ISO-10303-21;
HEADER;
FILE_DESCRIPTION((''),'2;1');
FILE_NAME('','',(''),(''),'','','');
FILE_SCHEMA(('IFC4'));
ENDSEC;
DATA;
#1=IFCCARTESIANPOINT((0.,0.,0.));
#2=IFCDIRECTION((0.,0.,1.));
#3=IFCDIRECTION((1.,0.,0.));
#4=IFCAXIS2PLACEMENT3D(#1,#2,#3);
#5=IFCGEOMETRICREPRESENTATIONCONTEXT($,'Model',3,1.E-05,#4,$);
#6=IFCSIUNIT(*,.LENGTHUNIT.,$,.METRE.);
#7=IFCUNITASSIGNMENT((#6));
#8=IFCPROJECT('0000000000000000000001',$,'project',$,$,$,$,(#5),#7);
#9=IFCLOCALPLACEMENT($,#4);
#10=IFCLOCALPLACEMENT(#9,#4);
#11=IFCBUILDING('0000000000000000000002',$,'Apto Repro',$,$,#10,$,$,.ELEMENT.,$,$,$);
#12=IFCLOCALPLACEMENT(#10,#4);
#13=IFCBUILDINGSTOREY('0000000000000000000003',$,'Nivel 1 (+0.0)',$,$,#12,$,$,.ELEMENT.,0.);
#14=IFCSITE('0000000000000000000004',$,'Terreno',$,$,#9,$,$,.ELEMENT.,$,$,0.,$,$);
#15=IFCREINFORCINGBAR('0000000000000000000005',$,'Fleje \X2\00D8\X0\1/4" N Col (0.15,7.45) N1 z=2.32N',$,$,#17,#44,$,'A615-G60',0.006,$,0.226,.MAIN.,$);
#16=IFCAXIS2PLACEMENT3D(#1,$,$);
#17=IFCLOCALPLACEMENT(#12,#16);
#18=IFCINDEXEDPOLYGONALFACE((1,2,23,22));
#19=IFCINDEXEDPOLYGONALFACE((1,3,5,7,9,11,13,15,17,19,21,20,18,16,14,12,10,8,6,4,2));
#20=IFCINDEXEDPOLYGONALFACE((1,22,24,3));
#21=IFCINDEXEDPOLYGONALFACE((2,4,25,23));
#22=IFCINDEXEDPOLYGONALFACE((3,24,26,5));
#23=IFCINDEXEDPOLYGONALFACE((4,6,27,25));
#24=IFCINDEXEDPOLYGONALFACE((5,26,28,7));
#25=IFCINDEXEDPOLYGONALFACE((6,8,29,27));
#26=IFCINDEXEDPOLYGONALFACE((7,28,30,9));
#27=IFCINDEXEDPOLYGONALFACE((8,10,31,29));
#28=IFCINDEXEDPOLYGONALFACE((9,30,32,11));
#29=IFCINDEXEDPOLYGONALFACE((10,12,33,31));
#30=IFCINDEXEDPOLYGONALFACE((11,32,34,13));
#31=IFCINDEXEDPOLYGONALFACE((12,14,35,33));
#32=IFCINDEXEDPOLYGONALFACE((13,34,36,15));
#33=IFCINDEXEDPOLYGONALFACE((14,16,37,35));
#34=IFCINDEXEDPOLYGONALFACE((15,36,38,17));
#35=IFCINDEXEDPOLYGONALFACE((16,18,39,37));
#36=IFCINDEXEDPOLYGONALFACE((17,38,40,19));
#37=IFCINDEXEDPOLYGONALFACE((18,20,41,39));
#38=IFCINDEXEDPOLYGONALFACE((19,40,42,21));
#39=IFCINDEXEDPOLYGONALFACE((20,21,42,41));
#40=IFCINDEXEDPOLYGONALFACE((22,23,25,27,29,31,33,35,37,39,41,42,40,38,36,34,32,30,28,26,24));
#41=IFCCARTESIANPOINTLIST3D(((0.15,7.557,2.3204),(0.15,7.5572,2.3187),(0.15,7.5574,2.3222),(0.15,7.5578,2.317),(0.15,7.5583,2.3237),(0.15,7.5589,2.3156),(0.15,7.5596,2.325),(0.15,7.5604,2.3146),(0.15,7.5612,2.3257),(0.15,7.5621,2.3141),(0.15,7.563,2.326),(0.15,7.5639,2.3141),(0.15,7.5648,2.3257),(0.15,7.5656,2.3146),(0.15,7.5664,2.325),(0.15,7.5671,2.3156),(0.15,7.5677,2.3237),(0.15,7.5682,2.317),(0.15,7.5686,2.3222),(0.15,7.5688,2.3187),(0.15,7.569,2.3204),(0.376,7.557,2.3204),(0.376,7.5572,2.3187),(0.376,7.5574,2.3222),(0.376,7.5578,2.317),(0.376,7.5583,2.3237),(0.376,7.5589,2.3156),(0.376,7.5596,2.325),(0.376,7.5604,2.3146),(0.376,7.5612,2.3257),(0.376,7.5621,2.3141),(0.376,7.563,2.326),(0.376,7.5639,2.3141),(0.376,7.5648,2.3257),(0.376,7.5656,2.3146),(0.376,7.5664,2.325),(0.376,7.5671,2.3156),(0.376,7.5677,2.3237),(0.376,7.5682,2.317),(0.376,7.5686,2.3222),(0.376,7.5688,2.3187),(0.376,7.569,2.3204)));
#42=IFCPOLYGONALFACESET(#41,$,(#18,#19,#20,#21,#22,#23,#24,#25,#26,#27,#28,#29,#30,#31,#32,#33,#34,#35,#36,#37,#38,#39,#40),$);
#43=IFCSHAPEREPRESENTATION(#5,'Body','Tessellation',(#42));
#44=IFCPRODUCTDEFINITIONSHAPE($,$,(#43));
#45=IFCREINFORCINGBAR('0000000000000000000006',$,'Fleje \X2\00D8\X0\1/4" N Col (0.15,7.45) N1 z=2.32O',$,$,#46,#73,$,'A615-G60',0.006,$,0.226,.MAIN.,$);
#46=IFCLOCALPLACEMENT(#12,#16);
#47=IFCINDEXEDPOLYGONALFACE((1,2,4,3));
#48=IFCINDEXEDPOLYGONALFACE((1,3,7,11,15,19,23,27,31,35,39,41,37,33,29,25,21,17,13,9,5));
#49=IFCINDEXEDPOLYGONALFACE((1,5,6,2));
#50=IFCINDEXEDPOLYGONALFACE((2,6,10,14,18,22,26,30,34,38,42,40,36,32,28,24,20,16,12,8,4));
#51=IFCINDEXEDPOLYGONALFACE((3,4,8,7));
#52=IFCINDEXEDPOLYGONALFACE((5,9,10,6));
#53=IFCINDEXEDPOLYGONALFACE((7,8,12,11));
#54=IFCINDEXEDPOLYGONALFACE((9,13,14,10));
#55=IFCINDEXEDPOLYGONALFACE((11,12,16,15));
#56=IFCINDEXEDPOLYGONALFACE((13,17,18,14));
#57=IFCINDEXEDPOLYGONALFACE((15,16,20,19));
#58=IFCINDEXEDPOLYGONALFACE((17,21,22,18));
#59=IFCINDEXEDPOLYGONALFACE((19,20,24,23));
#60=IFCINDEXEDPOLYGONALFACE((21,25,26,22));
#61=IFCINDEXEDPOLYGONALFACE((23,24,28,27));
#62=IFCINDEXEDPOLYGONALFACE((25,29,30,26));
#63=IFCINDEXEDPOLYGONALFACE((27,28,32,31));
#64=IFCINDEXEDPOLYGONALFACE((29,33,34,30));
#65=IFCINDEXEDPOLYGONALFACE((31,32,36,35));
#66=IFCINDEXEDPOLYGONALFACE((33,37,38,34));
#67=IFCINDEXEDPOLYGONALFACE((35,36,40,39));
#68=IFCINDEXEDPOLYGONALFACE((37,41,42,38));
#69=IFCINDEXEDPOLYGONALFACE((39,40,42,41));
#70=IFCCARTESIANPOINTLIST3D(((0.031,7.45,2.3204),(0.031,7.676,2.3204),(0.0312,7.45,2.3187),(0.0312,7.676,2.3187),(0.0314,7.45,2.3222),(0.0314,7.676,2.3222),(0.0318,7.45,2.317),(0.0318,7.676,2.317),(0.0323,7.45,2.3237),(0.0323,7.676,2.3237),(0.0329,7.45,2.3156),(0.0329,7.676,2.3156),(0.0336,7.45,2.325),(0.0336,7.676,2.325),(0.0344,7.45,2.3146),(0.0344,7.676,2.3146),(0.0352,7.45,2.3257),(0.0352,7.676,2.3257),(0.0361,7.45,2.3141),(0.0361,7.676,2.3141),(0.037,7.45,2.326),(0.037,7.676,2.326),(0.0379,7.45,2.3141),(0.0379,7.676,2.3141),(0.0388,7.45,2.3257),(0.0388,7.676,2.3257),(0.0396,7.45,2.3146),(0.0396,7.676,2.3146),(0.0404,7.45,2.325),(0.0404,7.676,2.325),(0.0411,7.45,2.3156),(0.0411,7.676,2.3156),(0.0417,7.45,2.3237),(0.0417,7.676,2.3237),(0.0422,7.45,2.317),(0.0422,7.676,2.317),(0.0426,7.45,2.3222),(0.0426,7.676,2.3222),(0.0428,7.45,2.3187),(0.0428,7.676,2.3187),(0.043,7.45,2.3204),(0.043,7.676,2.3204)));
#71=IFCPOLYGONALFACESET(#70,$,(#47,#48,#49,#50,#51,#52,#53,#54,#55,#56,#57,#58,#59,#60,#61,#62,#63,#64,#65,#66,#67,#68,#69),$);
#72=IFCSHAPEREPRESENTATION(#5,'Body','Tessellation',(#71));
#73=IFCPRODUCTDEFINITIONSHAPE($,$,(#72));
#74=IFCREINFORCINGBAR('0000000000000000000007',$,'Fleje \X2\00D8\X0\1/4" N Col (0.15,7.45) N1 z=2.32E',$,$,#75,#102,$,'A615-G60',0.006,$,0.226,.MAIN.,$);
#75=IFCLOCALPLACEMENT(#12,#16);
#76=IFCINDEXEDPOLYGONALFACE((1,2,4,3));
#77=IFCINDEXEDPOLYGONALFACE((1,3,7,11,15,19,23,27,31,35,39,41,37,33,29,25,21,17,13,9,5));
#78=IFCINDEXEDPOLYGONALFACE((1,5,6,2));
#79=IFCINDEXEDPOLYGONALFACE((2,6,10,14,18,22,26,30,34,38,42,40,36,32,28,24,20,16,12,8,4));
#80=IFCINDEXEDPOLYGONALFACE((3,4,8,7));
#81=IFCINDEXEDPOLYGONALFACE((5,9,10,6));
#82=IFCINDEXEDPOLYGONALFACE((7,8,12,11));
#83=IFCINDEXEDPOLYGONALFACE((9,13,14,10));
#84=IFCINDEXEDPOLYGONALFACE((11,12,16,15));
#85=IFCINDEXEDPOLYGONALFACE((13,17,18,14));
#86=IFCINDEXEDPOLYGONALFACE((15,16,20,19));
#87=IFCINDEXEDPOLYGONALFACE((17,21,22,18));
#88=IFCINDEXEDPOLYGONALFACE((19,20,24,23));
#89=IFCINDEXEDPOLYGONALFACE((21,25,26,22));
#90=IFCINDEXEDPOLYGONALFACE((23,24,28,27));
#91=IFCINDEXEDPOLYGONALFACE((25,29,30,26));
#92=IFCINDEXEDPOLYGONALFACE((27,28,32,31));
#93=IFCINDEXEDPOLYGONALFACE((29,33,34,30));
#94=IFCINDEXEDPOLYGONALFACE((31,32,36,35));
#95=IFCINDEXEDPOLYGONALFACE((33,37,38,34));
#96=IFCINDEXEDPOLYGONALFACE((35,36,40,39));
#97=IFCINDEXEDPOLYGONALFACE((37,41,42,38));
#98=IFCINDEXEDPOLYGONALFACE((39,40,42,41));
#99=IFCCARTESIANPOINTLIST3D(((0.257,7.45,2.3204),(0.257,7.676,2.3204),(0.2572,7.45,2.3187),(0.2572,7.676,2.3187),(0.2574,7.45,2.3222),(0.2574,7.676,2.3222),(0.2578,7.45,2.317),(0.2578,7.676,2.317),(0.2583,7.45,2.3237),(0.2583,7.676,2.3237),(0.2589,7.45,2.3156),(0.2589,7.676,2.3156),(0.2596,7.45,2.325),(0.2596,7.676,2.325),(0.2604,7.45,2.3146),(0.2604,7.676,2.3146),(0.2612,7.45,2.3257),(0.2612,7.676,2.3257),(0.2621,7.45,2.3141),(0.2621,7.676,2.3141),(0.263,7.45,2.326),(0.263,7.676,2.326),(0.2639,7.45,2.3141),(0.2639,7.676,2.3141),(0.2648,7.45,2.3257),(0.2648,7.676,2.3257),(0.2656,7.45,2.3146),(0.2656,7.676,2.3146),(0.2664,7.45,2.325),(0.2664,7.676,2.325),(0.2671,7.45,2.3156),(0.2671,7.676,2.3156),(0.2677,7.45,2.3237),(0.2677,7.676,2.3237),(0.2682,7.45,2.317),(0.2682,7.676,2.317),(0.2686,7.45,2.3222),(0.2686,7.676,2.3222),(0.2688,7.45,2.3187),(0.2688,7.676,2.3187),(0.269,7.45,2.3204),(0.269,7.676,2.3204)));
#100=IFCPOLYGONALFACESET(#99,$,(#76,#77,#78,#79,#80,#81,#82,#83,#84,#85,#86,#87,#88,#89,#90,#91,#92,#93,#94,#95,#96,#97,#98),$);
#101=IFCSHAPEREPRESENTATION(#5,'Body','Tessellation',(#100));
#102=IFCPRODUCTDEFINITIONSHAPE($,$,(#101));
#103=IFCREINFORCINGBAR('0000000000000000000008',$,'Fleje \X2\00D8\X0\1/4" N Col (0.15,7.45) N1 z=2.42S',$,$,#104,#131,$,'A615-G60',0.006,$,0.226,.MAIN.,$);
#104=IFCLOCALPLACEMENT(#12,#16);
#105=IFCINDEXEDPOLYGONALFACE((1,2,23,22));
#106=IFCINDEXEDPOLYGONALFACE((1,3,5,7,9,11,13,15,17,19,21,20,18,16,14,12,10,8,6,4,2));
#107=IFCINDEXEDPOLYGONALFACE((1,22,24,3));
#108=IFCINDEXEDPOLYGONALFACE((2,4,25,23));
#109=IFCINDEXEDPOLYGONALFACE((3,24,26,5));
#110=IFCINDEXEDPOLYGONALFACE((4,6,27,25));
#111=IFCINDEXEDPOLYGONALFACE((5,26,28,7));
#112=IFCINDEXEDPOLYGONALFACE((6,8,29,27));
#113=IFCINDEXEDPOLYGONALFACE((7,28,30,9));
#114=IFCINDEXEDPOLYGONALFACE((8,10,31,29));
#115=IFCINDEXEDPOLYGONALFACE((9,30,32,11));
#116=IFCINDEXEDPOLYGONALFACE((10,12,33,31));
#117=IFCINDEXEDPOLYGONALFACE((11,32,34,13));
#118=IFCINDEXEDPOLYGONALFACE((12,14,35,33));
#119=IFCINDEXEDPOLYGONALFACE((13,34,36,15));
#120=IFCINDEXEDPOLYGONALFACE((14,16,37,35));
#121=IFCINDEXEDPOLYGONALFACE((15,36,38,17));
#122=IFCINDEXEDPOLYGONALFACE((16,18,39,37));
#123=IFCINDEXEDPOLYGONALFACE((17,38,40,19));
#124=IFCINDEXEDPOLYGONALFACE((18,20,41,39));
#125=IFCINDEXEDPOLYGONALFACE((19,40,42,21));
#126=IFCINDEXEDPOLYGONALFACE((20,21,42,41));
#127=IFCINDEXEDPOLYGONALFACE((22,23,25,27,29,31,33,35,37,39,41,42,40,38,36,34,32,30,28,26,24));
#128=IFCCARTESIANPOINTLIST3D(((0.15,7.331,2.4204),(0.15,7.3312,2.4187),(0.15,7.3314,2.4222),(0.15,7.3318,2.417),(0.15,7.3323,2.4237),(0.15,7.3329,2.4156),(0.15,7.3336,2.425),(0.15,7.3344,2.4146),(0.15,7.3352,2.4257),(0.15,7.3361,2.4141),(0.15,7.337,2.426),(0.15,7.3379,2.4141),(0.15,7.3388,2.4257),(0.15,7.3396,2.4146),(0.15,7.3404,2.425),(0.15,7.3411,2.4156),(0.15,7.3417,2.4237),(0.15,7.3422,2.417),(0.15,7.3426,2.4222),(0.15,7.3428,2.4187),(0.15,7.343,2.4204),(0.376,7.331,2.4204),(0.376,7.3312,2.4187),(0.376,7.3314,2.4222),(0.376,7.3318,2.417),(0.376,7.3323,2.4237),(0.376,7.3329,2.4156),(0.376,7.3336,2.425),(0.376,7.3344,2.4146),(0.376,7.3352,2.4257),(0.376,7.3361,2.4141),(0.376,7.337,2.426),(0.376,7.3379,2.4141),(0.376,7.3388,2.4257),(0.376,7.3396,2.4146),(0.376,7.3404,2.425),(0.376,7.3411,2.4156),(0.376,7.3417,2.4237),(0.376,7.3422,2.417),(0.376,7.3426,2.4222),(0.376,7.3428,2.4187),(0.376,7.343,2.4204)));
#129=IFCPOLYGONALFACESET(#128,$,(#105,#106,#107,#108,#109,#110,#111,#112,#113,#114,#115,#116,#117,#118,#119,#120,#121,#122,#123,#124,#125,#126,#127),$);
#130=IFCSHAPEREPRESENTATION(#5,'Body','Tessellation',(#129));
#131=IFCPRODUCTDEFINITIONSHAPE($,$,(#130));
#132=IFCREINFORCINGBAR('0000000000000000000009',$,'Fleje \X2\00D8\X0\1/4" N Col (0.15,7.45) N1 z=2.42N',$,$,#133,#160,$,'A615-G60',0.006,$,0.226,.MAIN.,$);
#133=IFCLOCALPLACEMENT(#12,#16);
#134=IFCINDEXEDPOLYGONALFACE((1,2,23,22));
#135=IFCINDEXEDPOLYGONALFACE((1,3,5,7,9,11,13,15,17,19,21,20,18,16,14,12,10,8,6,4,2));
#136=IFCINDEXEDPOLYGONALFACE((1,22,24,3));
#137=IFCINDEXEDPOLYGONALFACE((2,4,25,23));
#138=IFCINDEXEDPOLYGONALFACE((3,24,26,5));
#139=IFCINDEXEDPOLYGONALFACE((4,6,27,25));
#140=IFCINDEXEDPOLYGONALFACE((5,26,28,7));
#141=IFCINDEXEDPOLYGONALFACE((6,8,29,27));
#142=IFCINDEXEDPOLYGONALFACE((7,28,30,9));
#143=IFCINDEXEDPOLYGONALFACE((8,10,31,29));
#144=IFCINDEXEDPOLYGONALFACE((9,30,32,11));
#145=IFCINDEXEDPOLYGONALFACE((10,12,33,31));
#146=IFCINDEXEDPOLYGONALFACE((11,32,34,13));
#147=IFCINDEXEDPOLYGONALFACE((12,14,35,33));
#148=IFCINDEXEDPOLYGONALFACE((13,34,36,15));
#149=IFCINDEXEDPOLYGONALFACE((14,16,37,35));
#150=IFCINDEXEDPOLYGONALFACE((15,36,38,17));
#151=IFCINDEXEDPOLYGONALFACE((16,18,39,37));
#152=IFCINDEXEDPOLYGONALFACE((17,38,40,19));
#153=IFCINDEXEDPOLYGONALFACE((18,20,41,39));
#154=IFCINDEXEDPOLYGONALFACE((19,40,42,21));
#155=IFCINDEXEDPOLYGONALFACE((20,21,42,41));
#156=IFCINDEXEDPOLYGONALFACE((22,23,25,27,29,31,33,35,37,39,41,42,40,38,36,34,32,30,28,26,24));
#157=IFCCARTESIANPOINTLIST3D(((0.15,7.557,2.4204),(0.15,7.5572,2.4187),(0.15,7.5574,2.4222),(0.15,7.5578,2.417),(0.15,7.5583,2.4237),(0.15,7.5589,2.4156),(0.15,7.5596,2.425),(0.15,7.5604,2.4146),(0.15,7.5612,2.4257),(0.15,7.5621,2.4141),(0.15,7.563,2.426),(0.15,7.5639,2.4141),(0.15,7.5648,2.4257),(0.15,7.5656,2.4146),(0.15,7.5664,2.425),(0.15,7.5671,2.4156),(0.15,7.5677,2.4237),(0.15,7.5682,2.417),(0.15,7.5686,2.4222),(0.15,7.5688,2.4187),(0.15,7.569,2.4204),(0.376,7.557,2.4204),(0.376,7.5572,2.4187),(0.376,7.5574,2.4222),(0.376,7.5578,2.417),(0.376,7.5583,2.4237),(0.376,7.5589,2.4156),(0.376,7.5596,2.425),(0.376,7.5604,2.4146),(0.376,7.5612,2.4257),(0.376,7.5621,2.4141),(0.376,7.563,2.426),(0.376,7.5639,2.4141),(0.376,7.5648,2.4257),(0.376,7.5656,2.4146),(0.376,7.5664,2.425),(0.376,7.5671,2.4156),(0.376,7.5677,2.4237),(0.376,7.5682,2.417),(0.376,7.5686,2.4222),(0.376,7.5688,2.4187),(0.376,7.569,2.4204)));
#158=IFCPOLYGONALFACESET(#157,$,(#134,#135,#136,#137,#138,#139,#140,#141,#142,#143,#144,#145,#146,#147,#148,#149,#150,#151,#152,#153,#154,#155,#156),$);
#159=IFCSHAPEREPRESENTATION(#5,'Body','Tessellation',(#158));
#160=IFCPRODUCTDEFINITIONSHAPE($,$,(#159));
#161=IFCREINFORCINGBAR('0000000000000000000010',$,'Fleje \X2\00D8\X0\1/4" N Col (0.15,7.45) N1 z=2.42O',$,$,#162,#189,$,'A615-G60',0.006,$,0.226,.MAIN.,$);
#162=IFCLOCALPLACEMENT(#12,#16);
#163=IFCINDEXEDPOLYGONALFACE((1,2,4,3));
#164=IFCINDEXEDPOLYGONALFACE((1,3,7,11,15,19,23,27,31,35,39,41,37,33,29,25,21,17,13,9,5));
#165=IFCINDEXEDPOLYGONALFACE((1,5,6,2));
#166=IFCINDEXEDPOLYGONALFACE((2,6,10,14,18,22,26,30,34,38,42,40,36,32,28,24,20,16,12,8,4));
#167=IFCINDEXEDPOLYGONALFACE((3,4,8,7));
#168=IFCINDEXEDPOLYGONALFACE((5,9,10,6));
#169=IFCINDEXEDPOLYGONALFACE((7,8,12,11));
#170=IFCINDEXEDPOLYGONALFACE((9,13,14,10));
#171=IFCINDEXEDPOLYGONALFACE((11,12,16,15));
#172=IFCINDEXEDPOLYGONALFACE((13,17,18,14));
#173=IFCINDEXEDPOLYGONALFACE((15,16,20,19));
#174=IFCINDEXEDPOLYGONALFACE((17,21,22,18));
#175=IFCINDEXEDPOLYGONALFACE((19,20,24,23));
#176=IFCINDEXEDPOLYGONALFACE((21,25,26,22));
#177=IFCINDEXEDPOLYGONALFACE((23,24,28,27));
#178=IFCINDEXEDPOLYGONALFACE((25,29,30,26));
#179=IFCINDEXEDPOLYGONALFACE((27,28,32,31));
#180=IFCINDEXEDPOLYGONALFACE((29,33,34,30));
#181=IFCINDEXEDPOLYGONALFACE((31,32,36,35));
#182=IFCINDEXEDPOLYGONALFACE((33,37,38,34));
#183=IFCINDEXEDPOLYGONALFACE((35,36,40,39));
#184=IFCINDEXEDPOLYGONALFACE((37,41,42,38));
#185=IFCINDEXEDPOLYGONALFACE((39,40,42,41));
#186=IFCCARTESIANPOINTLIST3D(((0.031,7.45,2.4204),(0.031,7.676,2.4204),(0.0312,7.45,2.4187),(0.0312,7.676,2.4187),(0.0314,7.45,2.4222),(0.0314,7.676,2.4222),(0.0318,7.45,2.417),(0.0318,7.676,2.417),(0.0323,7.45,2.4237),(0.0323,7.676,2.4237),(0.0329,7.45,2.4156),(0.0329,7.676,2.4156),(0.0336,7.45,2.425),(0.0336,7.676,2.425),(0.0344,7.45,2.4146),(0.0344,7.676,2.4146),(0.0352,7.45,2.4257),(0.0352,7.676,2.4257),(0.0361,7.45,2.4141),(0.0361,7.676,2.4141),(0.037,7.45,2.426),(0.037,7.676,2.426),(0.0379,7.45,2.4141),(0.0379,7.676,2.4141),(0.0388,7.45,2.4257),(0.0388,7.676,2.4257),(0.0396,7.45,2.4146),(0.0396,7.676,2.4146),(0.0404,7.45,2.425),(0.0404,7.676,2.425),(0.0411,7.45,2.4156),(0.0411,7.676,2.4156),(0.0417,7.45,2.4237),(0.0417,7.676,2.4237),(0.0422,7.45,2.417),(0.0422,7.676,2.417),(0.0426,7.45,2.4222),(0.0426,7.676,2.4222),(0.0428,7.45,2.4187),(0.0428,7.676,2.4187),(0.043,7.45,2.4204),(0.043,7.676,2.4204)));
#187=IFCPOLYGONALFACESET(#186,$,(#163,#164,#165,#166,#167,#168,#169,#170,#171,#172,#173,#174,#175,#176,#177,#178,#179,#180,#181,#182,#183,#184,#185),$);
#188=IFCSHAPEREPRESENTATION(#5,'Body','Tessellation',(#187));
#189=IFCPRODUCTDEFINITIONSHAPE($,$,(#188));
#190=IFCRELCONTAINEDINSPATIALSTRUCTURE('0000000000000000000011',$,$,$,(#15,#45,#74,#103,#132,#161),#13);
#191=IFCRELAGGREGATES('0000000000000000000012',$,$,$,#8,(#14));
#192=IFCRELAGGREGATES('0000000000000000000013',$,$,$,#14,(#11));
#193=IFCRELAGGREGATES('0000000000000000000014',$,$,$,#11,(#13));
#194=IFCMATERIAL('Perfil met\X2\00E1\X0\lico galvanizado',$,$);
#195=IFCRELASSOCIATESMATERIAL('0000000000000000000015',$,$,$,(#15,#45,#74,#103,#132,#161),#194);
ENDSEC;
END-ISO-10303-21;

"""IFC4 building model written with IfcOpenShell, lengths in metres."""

from ifc_helpers import new_model, si_unit, frame, origin_with_axes, origin_2d_with_axis, place, context, project, spatial, circle, extrude, material, element, save


model = new_model("IFC4")

# Units and contexts
model_context = context("Model", 3, precision=1e-05, world=origin_with_axes())
ifc_project = project(units=[si_unit("LENGTHUNIT", "METRE")], contexts=[model_context])

# Site, building, storey
site_placement = place(None, origin_with_axes())
site = spatial("IfcSite", under=ifc_project, at=site_placement, Name="Terreno", CompositionType="ELEMENT", RefElevation=0.0)
building_placement = place(site_placement, origin_with_axes())
building = spatial("IfcBuilding", under=site, at=building_placement, Name="Apto Repro", CompositionType="ELEMENT")
storey_placement = place(building_placement, origin_with_axes())
storey = spatial("IfcBuildingStorey", under=building, at=storey_placement, Name="Nivel 1 (+0.0)", CompositionType="ELEMENT", Elevation=0.0)

# Reinforcing bars
ifc_material = material(Name="Perfil metálico galvanizado")
reinforcing_bar_1_placement = place(storey_placement, origin_with_axes())
element("IfcReinforcingBar", 1, at=reinforcing_bar_1_placement, inside=storey, material=ifc_material, Name="Fleje Ø1/4\" N Col (0.15,7.45) N1 z=2.32N", SteelGrade="A615-G60", BarLength=0.226, NominalDiameter=0.006, PredefinedType="MAIN", context=model_context, shape_type="SweptSolid", body=[
    extrude(circle(Radius=0.006, at=origin_2d_with_axis()), frame((0.15, 7.563, 2.32), z_axis=(1.0, 0.0, 0.0), x_axis=(0.0, 0.0, 1.0)), (0.0, 0.0, 1.0), 0.226),
])
reinforcing_bar_2_placement = place(storey_placement, origin_with_axes())
element("IfcReinforcingBar", 2, at=reinforcing_bar_2_placement, inside=storey, material=ifc_material, Name="Fleje Ø1/4\" N Col (0.15,7.45) N1 z=2.32O", SteelGrade="A615-G60", BarLength=0.226, NominalDiameter=0.006, PredefinedType="MAIN", context=model_context, shape_type="SweptSolid", body=[
    extrude(circle(Radius=0.006, at=origin_2d_with_axis()), frame((0.037, 7.45, 2.32), z_axis=(0.0, 1.0, 0.0), x_axis=(0.0, 0.0, 1.0)), (0.0, 0.0, 1.0), 0.226),
])
reinforcing_bar_3_placement = place(storey_placement, origin_with_axes())
element("IfcReinforcingBar", 3, at=reinforcing_bar_3_placement, inside=storey, material=ifc_material, Name="Fleje Ø1/4\" N Col (0.15,7.45) N1 z=2.32E", SteelGrade="A615-G60", BarLength=0.226, NominalDiameter=0.006, PredefinedType="MAIN", context=model_context, shape_type="SweptSolid", body=[
    extrude(circle(Radius=0.006, at=origin_2d_with_axis()), frame((0.263, 7.45, 2.32), z_axis=(0.0, 1.0, 0.0), x_axis=(0.0, 0.0, 1.0)), (0.0, 0.0, 1.0), 0.226),
])
reinforcing_bar_4_placement = place(storey_placement, origin_with_axes())
element("IfcReinforcingBar", 4, at=reinforcing_bar_4_placement, inside=storey, material=ifc_material, Name="Fleje Ø1/4\" N Col (0.15,7.45) N1 z=2.42S", SteelGrade="A615-G60", BarLength=0.226, NominalDiameter=0.006, PredefinedType="MAIN", context=model_context, shape_type="SweptSolid", body=[
    extrude(circle(Radius=0.006, at=origin_2d_with_axis()), frame((0.15, 7.337, 2.42), z_axis=(1.0, 0.0, 0.0), x_axis=(0.0, 0.0, 1.0)), (0.0, 0.0, 1.0), 0.226),
])
reinforcing_bar_5_placement = place(storey_placement, origin_with_axes())
element("IfcReinforcingBar", 5, at=reinforcing_bar_5_placement, inside=storey, material=ifc_material, Name="Fleje Ø1/4\" N Col (0.15,7.45) N1 z=2.42N", SteelGrade="A615-G60", BarLength=0.226, NominalDiameter=0.006, PredefinedType="MAIN", context=model_context, shape_type="SweptSolid", body=[
    extrude(circle(Radius=0.006, at=origin_2d_with_axis()), frame((0.15, 7.563, 2.42), z_axis=(1.0, 0.0, 0.0), x_axis=(0.0, 0.0, 1.0)), (0.0, 0.0, 1.0), 0.226),
])
reinforcing_bar_6_placement = place(storey_placement, origin_with_axes())
element("IfcReinforcingBar", 6, at=reinforcing_bar_6_placement, inside=storey, material=ifc_material, Name="Fleje Ø1/4\" N Col (0.15,7.45) N1 z=2.42O", SteelGrade="A615-G60", BarLength=0.226, NominalDiameter=0.006, PredefinedType="MAIN", context=model_context, shape_type="SweptSolid", body=[
    extrude(circle(Radius=0.006, at=origin_2d_with_axis()), frame((0.037, 7.45, 2.42), z_axis=(0.0, 1.0, 0.0), x_axis=(0.0, 0.0, 1.0)), (0.0, 0.0, 1.0), 0.226),
])

save(model, "model.ifc")
